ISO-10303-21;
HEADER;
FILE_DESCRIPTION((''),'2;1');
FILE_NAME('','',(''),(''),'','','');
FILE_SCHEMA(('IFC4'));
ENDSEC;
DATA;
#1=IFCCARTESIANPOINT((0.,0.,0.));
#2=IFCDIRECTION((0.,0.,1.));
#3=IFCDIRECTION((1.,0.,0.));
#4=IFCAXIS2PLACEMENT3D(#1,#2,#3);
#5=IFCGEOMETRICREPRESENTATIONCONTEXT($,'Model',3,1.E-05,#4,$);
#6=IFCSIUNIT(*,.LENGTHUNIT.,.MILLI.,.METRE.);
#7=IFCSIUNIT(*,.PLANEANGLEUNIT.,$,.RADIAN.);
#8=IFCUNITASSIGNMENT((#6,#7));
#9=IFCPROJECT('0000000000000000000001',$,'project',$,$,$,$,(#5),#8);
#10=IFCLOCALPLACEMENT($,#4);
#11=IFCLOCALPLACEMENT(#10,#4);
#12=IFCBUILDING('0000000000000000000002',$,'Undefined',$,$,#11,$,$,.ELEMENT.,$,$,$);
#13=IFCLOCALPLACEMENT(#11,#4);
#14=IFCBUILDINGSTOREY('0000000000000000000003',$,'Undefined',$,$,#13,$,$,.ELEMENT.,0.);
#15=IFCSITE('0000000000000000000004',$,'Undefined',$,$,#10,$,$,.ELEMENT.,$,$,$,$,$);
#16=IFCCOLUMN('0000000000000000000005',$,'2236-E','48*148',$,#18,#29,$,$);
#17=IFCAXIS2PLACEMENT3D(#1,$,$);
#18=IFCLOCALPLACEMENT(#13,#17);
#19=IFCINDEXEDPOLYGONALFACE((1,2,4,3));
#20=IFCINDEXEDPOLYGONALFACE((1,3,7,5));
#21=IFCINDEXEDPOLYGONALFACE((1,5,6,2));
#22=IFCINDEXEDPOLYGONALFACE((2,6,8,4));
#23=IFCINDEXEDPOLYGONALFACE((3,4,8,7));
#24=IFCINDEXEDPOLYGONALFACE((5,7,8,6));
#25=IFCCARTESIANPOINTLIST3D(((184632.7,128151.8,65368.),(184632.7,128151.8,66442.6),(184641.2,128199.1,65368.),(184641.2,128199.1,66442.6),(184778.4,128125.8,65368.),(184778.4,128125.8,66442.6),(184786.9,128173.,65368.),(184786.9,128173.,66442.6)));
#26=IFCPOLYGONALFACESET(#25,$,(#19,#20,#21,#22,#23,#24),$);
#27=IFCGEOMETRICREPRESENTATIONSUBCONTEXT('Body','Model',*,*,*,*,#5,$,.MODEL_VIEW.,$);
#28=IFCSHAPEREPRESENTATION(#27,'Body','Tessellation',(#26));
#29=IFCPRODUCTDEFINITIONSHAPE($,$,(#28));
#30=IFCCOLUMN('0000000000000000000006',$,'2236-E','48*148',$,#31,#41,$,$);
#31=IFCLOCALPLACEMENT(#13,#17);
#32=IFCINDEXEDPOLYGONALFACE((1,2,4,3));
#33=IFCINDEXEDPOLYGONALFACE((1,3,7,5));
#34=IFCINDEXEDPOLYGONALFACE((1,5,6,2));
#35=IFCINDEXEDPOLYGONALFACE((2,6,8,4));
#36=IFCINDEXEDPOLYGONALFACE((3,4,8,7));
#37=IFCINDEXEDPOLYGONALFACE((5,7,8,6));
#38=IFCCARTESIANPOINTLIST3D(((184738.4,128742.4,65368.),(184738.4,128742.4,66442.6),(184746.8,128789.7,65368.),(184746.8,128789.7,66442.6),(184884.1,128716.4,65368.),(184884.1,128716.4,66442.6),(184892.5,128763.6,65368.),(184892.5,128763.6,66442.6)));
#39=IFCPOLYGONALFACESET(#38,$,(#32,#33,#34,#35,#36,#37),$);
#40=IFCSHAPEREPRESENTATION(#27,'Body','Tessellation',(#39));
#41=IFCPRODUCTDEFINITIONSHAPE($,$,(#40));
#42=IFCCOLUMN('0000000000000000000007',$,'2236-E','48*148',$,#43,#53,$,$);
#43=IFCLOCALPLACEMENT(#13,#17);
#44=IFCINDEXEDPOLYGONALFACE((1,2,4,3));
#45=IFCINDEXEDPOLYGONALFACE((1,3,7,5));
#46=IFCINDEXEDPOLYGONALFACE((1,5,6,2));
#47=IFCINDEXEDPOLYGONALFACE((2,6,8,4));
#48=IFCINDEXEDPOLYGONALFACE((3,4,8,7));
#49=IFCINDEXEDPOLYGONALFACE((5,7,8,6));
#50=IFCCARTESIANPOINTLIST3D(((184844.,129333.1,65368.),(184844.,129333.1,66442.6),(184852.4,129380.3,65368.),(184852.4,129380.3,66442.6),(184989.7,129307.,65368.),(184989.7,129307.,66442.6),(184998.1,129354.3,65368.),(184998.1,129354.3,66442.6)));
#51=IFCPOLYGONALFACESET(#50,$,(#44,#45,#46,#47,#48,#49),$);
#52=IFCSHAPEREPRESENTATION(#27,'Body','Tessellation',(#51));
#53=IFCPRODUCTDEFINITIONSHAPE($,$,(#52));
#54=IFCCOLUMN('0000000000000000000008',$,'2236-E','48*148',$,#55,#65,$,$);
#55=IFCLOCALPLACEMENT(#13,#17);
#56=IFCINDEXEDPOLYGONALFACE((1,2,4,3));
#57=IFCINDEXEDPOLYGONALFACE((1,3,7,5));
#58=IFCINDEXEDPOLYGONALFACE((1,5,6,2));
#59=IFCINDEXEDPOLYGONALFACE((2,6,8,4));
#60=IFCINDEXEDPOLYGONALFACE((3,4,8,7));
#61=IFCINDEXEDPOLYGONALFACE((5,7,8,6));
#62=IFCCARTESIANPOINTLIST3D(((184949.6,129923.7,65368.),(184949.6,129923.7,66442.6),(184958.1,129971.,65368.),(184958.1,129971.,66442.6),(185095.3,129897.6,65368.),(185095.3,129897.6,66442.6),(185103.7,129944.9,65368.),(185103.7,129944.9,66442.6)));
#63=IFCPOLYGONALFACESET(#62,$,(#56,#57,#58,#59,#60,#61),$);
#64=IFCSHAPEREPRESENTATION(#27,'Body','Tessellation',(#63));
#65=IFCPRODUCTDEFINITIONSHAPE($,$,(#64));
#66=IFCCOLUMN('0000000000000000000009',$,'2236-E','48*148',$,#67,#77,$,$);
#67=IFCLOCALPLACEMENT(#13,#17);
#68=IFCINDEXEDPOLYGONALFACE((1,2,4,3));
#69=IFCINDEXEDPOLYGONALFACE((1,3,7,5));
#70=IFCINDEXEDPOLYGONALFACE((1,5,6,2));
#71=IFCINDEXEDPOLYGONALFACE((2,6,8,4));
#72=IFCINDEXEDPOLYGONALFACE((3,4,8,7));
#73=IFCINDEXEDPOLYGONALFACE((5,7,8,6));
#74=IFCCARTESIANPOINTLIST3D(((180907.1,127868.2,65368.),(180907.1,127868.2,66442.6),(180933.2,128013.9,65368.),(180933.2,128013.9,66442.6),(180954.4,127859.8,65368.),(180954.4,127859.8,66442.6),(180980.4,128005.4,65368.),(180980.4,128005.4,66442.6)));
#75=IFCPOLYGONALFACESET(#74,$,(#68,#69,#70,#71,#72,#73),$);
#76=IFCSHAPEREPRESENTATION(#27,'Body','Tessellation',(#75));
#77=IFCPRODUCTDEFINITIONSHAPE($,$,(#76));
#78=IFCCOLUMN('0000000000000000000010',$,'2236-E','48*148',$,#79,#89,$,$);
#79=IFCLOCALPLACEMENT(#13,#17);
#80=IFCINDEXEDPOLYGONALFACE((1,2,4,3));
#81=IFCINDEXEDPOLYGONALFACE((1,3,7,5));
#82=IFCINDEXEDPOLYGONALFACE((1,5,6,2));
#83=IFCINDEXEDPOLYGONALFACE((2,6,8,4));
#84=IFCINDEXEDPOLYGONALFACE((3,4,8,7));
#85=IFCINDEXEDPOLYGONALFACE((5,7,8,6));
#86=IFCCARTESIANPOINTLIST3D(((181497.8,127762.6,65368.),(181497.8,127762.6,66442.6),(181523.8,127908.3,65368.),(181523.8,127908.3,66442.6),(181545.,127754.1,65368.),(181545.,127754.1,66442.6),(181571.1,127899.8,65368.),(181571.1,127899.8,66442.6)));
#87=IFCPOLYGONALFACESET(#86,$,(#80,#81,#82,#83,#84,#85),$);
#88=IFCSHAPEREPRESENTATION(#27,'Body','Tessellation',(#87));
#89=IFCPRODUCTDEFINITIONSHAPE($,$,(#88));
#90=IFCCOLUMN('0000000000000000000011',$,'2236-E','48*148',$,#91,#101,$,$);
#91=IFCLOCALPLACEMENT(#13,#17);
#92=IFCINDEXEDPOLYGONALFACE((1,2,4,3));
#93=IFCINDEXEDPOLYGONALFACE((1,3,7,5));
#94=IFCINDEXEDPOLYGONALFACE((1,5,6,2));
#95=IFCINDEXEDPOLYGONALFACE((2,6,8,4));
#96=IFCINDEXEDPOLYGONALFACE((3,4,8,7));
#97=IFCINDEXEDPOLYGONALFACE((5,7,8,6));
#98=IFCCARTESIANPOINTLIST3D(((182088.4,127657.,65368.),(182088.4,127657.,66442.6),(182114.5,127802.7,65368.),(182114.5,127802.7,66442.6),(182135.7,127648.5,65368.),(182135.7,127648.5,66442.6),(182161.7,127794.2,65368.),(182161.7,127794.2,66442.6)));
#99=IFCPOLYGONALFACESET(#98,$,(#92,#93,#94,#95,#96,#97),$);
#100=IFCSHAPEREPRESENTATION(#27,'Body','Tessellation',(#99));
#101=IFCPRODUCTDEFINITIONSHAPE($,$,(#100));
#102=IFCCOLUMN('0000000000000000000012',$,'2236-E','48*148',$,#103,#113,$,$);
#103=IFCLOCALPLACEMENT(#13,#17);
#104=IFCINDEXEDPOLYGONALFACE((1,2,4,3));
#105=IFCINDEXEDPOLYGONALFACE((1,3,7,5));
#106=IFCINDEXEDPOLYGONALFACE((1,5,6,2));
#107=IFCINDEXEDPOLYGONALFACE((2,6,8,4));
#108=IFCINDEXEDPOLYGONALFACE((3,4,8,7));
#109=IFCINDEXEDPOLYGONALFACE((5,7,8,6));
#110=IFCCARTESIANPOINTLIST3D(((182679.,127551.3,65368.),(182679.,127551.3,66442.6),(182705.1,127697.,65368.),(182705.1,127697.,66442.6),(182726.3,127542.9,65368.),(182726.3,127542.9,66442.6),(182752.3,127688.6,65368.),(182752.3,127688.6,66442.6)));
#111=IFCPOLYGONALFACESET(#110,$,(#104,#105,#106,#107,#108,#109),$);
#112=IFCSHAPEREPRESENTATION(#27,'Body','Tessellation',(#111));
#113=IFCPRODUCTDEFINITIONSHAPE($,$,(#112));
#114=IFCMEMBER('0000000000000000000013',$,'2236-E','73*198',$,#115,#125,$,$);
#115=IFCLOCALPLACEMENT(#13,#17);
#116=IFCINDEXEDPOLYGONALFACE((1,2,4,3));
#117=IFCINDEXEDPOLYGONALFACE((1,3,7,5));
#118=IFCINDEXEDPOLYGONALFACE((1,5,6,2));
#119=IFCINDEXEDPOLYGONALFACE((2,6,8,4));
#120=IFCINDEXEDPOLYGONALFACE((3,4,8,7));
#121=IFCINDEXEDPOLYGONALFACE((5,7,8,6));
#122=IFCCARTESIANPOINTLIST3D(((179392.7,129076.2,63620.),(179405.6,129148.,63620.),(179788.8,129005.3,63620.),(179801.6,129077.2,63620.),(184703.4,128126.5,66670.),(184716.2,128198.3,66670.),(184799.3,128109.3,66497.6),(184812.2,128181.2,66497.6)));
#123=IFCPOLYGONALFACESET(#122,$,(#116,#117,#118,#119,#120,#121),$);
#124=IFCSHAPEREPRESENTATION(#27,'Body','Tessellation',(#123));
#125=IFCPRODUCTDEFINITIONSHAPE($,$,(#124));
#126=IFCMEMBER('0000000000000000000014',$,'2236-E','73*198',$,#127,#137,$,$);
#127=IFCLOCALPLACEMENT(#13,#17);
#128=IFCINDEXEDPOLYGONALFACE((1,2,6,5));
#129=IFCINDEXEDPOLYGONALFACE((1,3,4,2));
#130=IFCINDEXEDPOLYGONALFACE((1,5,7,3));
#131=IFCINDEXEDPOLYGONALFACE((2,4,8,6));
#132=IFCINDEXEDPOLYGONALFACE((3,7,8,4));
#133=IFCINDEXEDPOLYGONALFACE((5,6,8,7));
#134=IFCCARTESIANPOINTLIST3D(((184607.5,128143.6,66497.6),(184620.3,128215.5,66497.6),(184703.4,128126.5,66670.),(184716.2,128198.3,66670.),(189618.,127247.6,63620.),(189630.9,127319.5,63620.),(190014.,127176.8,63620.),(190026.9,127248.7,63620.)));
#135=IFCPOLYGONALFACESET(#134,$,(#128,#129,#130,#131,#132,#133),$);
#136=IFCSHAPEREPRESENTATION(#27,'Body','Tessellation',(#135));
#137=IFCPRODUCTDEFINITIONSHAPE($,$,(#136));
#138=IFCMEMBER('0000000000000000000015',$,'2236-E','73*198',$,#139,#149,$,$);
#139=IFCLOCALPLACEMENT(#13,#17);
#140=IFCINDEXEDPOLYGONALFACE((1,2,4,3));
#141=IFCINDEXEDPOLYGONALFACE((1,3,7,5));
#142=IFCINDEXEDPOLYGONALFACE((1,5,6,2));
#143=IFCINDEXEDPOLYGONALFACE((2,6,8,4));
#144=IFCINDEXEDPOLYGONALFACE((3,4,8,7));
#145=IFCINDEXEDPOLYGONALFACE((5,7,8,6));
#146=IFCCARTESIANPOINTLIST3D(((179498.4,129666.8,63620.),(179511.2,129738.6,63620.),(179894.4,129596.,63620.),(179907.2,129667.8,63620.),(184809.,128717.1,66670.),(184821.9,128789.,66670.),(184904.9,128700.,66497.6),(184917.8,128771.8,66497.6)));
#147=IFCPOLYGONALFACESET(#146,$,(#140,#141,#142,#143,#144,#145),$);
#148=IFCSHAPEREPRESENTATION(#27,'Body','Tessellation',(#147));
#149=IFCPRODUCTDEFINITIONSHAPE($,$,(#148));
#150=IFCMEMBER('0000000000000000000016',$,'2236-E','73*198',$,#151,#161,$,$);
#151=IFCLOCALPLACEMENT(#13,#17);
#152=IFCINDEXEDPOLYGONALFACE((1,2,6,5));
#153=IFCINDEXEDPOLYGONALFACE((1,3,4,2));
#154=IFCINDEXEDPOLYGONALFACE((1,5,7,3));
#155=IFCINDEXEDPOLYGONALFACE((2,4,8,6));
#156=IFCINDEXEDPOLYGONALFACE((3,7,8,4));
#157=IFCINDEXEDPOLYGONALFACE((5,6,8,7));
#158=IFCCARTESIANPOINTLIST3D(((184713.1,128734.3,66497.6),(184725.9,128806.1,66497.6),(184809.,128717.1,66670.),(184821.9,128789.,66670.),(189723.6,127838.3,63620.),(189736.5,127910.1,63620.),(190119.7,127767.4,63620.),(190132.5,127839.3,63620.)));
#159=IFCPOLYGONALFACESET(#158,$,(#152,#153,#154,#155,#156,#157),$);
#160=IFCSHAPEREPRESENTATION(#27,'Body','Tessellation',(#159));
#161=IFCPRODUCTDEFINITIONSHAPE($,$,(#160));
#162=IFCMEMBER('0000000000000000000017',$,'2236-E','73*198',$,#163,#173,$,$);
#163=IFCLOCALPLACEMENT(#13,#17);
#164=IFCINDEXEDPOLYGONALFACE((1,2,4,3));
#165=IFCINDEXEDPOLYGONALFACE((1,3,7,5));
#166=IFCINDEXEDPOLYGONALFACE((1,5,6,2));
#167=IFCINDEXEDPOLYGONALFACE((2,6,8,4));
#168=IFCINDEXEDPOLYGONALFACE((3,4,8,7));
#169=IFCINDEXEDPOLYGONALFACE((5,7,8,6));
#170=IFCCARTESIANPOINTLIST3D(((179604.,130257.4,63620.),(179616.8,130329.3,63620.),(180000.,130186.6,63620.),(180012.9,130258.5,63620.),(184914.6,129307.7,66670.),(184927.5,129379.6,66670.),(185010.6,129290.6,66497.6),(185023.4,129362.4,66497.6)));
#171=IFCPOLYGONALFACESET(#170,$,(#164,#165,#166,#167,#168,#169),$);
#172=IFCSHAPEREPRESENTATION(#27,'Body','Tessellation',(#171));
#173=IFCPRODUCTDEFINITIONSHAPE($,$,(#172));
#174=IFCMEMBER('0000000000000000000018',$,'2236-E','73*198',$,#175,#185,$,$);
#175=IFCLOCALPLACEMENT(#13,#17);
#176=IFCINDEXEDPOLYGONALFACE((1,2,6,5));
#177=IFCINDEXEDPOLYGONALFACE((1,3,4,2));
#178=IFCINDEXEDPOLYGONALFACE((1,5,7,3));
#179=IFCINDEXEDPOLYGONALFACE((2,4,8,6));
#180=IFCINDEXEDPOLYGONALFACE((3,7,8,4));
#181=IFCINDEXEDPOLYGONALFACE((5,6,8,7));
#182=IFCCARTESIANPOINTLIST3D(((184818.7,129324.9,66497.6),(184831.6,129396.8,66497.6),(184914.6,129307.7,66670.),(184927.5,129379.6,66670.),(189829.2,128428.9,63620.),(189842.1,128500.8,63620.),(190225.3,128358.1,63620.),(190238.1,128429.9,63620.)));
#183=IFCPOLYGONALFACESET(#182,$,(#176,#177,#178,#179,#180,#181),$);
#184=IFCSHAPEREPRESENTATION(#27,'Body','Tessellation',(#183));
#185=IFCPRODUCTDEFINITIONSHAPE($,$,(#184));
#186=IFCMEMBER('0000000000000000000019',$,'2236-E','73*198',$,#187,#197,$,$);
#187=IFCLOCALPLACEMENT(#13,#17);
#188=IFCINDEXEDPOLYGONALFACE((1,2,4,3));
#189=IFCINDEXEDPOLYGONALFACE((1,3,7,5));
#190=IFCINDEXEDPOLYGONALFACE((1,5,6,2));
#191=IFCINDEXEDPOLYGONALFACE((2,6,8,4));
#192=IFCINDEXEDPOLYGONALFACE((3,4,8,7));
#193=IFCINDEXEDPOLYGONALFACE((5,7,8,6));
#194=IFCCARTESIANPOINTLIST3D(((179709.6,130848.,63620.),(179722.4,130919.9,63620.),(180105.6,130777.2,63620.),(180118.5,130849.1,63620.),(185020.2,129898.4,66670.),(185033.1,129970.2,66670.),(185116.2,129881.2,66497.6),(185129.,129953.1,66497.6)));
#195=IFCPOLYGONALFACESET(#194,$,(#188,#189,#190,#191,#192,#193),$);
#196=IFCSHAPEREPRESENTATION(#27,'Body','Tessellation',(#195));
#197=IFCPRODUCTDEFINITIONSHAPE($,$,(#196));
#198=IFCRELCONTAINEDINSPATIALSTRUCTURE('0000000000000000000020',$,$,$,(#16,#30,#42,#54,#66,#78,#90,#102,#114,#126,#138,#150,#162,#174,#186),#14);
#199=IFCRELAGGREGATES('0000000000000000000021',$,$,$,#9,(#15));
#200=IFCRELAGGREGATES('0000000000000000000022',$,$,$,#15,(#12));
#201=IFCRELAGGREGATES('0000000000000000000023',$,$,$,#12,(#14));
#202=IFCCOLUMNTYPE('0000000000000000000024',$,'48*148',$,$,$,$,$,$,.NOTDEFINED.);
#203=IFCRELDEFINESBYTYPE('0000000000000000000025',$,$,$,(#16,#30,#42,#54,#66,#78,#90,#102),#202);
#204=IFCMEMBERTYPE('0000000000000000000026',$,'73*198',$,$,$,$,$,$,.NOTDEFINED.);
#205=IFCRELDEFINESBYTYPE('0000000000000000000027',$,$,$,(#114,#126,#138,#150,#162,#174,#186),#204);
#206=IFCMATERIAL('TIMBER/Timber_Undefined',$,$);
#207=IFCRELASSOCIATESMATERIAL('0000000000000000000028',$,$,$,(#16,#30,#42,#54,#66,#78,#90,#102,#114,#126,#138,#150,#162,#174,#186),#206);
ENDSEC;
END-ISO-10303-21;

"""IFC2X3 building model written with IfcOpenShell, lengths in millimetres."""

from ifc_helpers import new_model, si_unit, frame, origin_with_axes, origin_2d_with_axis, place, context, subcontext, project, spatial, rectangle, extrude, clip, halfspace, material, type_object, element, save


model = new_model("IFC2X3")

# Units and contexts
model_context = context("Model", 3, precision=1e-05, world=origin_with_axes())
body_context = subcontext(model_context, "Body", "Model", "MODEL_VIEW")
ifc_project = project(units=[si_unit("LENGTHUNIT", "METRE", prefix="MILLI"), si_unit("PLANEANGLEUNIT", "RADIAN")], contexts=[model_context])

# Site, building, storey
site_placement = place(None, origin_with_axes())
site = spatial("IfcSite", under=ifc_project, at=site_placement, Name="Undefined", CompositionType="ELEMENT")
building_placement = place(site_placement, origin_with_axes())
building = spatial("IfcBuilding", under=site, at=building_placement, Name="Undefined", CompositionType="ELEMENT")
storey_placement = place(building_placement, origin_with_axes())
storey = spatial("IfcBuildingStorey", under=building, at=storey_placement, Name="Undefined", CompositionType="ELEMENT", Elevation=0.0)

# Columns
ifc_material = material(Name="TIMBER/Timber_Undefined")
column_type = type_object("IfcColumnType", Name="48*148", PredefinedType="NOTDEFINED")
for number, where, z_axis, x_axis, name in (
    (1, (184709.8, 128162.4, 66442.6), (0.0, 0.0, -1.0), (0.176032, 0.984385, 0.0), "2236-E"),
    (2, (184815.4, 128753.0, 66442.6), (0.0, 0.0, -1.0), (0.176032, 0.984385, 0.0), "2236-E"),
    (3, (184921.1, 129343.7, 66442.6), (0.0, 0.0, -1.0), (0.176032, 0.984385, 0.0), "2236-E"),
    (4, (185026.7, 129934.3, 66442.6), (0.0, 0.0, -1.0), (0.176032, 0.984385, 0.0), "2236-E"),
    (5, (180943.8, 127936.8, 66442.6), (0.0, 0.0, -1.0), (0.984385, -0.176032, 0.0), "2236-E"),
    (6, (181534.4, 127831.2, 66442.6), (0.0, 0.0, -1.0), (0.984385, -0.176032, 0.0), "2236-E"),
    (7, (182125.1, 127725.6, 66442.6), (0.0, 0.0, -1.0), (0.984385, -0.176032, 0.0), "2236-E"),
    (8, (182715.7, 127620.0, 66442.6), (0.0, 0.0, -1.0), (0.984385, -0.176032, 0.0), "2236-E"),
):
    element("IfcColumn", number, at=place(storey_placement, frame(where, z_axis=z_axis, x_axis=x_axis)), inside=storey, type_object=column_type, material=ifc_material, Name=name, Description="48*148", context=body_context, shape_type="SweptSolid", body=[
        extrude(rectangle(XDim=148.0, YDim=48.0, at=origin_2d_with_axis()), frame((0.0, 0.0, 1074.6), z_axis=(0.0, 0.0, -1.0), x_axis=(0.0, 1.0, 0.0)), (0.0, 0.0, 1.0), 1074.6),
    ])

# Members
member_type = type_object("IfcMemberType", Name="73*198", PredefinedType="NOTDEFINED")
member_1_placement = place(storey_placement, frame((184757.8, 128153.8, 66583.8), z_axis=(0.176032, 0.984385, 0.0), x_axis=(-0.85692, 0.153238, -0.492144)))
element("IfcMember", 9, at=member_1_placement, inside=storey, type_object=member_type, material=ifc_material, Name="2236-E", Description="73*198", context=body_context, shape_type="Clipping", body=[
    clip(extrude(rectangle(XDim=198.0, YDim=73.0, at=origin_2d_with_axis()), frame((9448.4, 0.0, 0.0), z_axis=(-1.0, 0.0, 0.0), x_axis=(0.0, -1.0, 0.0)), (0.0, 0.0, 1.0), 9448.5), halfspace(frame((6270.8, 140.5, 36.5), z_axis=(0.492144, -0.870514, 0.0), x_axis=(0.0, 0.0, -1.0)), False)),
])
member_2_placement = place(storey_placement, frame((184661.9, 128171.0, 66583.8), z_axis=(-0.176032, -0.984385, 0.0), x_axis=(0.85692, -0.153238, -0.492144)))
element("IfcMember", 10, at=member_2_placement, inside=storey, type_object=member_type, material=ifc_material, Name="2236-E", Description="73*198", context=body_context, shape_type="Clipping", body=[
    clip(extrude(rectangle(XDim=198.0, YDim=73.0, at=origin_2d_with_axis()), frame((9448.4, 0.0, 0.0), z_axis=(-1.0, 0.0, 0.0), x_axis=(0.0, -1.0, 0.0)), (0.0, 0.0, 1.0), 9448.5), halfspace(frame((6183.8, 91.3, 36.5), z_axis=(0.492144, -0.870514, 0.0), x_axis=(0.0, 0.0, -1.0)), False)),
])
member_3_placement = place(storey_placement, frame((184863.4, 128744.5, 66583.8), z_axis=(0.176032, 0.984385, 0.0), x_axis=(-0.85692, 0.153238, -0.492144)))
element("IfcMember", 11, at=member_3_placement, inside=storey, type_object=member_type, material=ifc_material, Name="2236-E", Description="73*198", context=body_context, shape_type="Clipping", body=[
    clip(extrude(rectangle(XDim=198.0, YDim=73.0, at=origin_2d_with_axis()), frame((9448.4, 0.0, 0.0), z_axis=(-1.0, 0.0, 0.0), x_axis=(0.0, -1.0, 0.0)), (0.0, 0.0, 1.0), 9448.5), halfspace(frame((6270.8, 140.5, 36.5), z_axis=(0.492144, -0.870514, 0.0), x_axis=(0.0, 0.0, -1.0)), False)),
])
member_4_placement = place(storey_placement, frame((184767.5, 128761.6, 66583.8), z_axis=(-0.176032, -0.984385, 0.0), x_axis=(0.85692, -0.153238, -0.492144)))
element("IfcMember", 12, at=member_4_placement, inside=storey, type_object=member_type, material=ifc_material, Name="2236-E", Description="73*198", context=body_context, shape_type="Clipping", body=[
    clip(extrude(rectangle(XDim=198.0, YDim=73.0, at=origin_2d_with_axis()), frame((9448.4, 0.0, 0.0), z_axis=(-1.0, 0.0, 0.0), x_axis=(0.0, -1.0, 0.0)), (0.0, 0.0, 1.0), 9448.5), halfspace(frame((6183.8, 91.3, 36.5), z_axis=(0.492144, -0.870514, 0.0), x_axis=(0.0, 0.0, -1.0)), False)),
])
member_5_placement = place(storey_placement, frame((184969.0, 129335.1, 66583.8), z_axis=(0.176032, 0.984385, 0.0), x_axis=(-0.85692, 0.153238, -0.492144)))
element("IfcMember", 13, at=member_5_placement, inside=storey, type_object=member_type, material=ifc_material, Name="2236-E", Description="73*198", context=body_context, shape_type="Clipping", body=[
    clip(extrude(rectangle(XDim=198.0, YDim=73.0, at=origin_2d_with_axis()), frame((9448.4, 0.0, 0.0), z_axis=(-1.0, 0.0, 0.0), x_axis=(0.0, -1.0, 0.0)), (0.0, 0.0, 1.0), 9448.5), halfspace(frame((6270.8, 140.5, 36.5), z_axis=(0.492144, -0.870514, 0.0), x_axis=(0.0, 0.0, -1.0)), False)),
])
member_6_placement = place(storey_placement, frame((184873.1, 129352.2, 66583.8), z_axis=(-0.176032, -0.984385, 0.0), x_axis=(0.85692, -0.153238, -0.492144)))
element("IfcMember", 14, at=member_6_placement, inside=storey, type_object=member_type, material=ifc_material, Name="2236-E", Description="73*198", context=body_context, shape_type="Clipping", body=[
    clip(extrude(rectangle(XDim=198.0, YDim=73.0, at=origin_2d_with_axis()), frame((9448.4, 0.0, 0.0), z_axis=(-1.0, 0.0, 0.0), x_axis=(0.0, -1.0, 0.0)), (0.0, 0.0, 1.0), 9448.5), halfspace(frame((6183.8, 91.3, 36.5), z_axis=(0.492144, -0.870514, 0.0), x_axis=(0.0, 0.0, -1.0)), False)),
])
member_7_placement = place(storey_placement, frame((185074.6, 129925.7, 66583.8), z_axis=(0.176032, 0.984385, 0.0), x_axis=(-0.85692, 0.153238, -0.492144)))
element("IfcMember", 15, at=member_7_placement, inside=storey, type_object=member_type, material=ifc_material, Name="2236-E", Description="73*198", context=body_context, shape_type="Clipping", body=[
    clip(extrude(rectangle(XDim=198.0, YDim=73.0, at=origin_2d_with_axis()), frame((9448.4, 0.0, 0.0), z_axis=(-1.0, 0.0, 0.0), x_axis=(0.0, -1.0, 0.0)), (0.0, 0.0, 1.0), 9448.5), halfspace(frame((6270.8, 140.5, 36.5), z_axis=(0.492144, -0.870514, 0.0), x_axis=(0.0, 0.0, -1.0)), False)),
])

save(model, "model.ifc")
